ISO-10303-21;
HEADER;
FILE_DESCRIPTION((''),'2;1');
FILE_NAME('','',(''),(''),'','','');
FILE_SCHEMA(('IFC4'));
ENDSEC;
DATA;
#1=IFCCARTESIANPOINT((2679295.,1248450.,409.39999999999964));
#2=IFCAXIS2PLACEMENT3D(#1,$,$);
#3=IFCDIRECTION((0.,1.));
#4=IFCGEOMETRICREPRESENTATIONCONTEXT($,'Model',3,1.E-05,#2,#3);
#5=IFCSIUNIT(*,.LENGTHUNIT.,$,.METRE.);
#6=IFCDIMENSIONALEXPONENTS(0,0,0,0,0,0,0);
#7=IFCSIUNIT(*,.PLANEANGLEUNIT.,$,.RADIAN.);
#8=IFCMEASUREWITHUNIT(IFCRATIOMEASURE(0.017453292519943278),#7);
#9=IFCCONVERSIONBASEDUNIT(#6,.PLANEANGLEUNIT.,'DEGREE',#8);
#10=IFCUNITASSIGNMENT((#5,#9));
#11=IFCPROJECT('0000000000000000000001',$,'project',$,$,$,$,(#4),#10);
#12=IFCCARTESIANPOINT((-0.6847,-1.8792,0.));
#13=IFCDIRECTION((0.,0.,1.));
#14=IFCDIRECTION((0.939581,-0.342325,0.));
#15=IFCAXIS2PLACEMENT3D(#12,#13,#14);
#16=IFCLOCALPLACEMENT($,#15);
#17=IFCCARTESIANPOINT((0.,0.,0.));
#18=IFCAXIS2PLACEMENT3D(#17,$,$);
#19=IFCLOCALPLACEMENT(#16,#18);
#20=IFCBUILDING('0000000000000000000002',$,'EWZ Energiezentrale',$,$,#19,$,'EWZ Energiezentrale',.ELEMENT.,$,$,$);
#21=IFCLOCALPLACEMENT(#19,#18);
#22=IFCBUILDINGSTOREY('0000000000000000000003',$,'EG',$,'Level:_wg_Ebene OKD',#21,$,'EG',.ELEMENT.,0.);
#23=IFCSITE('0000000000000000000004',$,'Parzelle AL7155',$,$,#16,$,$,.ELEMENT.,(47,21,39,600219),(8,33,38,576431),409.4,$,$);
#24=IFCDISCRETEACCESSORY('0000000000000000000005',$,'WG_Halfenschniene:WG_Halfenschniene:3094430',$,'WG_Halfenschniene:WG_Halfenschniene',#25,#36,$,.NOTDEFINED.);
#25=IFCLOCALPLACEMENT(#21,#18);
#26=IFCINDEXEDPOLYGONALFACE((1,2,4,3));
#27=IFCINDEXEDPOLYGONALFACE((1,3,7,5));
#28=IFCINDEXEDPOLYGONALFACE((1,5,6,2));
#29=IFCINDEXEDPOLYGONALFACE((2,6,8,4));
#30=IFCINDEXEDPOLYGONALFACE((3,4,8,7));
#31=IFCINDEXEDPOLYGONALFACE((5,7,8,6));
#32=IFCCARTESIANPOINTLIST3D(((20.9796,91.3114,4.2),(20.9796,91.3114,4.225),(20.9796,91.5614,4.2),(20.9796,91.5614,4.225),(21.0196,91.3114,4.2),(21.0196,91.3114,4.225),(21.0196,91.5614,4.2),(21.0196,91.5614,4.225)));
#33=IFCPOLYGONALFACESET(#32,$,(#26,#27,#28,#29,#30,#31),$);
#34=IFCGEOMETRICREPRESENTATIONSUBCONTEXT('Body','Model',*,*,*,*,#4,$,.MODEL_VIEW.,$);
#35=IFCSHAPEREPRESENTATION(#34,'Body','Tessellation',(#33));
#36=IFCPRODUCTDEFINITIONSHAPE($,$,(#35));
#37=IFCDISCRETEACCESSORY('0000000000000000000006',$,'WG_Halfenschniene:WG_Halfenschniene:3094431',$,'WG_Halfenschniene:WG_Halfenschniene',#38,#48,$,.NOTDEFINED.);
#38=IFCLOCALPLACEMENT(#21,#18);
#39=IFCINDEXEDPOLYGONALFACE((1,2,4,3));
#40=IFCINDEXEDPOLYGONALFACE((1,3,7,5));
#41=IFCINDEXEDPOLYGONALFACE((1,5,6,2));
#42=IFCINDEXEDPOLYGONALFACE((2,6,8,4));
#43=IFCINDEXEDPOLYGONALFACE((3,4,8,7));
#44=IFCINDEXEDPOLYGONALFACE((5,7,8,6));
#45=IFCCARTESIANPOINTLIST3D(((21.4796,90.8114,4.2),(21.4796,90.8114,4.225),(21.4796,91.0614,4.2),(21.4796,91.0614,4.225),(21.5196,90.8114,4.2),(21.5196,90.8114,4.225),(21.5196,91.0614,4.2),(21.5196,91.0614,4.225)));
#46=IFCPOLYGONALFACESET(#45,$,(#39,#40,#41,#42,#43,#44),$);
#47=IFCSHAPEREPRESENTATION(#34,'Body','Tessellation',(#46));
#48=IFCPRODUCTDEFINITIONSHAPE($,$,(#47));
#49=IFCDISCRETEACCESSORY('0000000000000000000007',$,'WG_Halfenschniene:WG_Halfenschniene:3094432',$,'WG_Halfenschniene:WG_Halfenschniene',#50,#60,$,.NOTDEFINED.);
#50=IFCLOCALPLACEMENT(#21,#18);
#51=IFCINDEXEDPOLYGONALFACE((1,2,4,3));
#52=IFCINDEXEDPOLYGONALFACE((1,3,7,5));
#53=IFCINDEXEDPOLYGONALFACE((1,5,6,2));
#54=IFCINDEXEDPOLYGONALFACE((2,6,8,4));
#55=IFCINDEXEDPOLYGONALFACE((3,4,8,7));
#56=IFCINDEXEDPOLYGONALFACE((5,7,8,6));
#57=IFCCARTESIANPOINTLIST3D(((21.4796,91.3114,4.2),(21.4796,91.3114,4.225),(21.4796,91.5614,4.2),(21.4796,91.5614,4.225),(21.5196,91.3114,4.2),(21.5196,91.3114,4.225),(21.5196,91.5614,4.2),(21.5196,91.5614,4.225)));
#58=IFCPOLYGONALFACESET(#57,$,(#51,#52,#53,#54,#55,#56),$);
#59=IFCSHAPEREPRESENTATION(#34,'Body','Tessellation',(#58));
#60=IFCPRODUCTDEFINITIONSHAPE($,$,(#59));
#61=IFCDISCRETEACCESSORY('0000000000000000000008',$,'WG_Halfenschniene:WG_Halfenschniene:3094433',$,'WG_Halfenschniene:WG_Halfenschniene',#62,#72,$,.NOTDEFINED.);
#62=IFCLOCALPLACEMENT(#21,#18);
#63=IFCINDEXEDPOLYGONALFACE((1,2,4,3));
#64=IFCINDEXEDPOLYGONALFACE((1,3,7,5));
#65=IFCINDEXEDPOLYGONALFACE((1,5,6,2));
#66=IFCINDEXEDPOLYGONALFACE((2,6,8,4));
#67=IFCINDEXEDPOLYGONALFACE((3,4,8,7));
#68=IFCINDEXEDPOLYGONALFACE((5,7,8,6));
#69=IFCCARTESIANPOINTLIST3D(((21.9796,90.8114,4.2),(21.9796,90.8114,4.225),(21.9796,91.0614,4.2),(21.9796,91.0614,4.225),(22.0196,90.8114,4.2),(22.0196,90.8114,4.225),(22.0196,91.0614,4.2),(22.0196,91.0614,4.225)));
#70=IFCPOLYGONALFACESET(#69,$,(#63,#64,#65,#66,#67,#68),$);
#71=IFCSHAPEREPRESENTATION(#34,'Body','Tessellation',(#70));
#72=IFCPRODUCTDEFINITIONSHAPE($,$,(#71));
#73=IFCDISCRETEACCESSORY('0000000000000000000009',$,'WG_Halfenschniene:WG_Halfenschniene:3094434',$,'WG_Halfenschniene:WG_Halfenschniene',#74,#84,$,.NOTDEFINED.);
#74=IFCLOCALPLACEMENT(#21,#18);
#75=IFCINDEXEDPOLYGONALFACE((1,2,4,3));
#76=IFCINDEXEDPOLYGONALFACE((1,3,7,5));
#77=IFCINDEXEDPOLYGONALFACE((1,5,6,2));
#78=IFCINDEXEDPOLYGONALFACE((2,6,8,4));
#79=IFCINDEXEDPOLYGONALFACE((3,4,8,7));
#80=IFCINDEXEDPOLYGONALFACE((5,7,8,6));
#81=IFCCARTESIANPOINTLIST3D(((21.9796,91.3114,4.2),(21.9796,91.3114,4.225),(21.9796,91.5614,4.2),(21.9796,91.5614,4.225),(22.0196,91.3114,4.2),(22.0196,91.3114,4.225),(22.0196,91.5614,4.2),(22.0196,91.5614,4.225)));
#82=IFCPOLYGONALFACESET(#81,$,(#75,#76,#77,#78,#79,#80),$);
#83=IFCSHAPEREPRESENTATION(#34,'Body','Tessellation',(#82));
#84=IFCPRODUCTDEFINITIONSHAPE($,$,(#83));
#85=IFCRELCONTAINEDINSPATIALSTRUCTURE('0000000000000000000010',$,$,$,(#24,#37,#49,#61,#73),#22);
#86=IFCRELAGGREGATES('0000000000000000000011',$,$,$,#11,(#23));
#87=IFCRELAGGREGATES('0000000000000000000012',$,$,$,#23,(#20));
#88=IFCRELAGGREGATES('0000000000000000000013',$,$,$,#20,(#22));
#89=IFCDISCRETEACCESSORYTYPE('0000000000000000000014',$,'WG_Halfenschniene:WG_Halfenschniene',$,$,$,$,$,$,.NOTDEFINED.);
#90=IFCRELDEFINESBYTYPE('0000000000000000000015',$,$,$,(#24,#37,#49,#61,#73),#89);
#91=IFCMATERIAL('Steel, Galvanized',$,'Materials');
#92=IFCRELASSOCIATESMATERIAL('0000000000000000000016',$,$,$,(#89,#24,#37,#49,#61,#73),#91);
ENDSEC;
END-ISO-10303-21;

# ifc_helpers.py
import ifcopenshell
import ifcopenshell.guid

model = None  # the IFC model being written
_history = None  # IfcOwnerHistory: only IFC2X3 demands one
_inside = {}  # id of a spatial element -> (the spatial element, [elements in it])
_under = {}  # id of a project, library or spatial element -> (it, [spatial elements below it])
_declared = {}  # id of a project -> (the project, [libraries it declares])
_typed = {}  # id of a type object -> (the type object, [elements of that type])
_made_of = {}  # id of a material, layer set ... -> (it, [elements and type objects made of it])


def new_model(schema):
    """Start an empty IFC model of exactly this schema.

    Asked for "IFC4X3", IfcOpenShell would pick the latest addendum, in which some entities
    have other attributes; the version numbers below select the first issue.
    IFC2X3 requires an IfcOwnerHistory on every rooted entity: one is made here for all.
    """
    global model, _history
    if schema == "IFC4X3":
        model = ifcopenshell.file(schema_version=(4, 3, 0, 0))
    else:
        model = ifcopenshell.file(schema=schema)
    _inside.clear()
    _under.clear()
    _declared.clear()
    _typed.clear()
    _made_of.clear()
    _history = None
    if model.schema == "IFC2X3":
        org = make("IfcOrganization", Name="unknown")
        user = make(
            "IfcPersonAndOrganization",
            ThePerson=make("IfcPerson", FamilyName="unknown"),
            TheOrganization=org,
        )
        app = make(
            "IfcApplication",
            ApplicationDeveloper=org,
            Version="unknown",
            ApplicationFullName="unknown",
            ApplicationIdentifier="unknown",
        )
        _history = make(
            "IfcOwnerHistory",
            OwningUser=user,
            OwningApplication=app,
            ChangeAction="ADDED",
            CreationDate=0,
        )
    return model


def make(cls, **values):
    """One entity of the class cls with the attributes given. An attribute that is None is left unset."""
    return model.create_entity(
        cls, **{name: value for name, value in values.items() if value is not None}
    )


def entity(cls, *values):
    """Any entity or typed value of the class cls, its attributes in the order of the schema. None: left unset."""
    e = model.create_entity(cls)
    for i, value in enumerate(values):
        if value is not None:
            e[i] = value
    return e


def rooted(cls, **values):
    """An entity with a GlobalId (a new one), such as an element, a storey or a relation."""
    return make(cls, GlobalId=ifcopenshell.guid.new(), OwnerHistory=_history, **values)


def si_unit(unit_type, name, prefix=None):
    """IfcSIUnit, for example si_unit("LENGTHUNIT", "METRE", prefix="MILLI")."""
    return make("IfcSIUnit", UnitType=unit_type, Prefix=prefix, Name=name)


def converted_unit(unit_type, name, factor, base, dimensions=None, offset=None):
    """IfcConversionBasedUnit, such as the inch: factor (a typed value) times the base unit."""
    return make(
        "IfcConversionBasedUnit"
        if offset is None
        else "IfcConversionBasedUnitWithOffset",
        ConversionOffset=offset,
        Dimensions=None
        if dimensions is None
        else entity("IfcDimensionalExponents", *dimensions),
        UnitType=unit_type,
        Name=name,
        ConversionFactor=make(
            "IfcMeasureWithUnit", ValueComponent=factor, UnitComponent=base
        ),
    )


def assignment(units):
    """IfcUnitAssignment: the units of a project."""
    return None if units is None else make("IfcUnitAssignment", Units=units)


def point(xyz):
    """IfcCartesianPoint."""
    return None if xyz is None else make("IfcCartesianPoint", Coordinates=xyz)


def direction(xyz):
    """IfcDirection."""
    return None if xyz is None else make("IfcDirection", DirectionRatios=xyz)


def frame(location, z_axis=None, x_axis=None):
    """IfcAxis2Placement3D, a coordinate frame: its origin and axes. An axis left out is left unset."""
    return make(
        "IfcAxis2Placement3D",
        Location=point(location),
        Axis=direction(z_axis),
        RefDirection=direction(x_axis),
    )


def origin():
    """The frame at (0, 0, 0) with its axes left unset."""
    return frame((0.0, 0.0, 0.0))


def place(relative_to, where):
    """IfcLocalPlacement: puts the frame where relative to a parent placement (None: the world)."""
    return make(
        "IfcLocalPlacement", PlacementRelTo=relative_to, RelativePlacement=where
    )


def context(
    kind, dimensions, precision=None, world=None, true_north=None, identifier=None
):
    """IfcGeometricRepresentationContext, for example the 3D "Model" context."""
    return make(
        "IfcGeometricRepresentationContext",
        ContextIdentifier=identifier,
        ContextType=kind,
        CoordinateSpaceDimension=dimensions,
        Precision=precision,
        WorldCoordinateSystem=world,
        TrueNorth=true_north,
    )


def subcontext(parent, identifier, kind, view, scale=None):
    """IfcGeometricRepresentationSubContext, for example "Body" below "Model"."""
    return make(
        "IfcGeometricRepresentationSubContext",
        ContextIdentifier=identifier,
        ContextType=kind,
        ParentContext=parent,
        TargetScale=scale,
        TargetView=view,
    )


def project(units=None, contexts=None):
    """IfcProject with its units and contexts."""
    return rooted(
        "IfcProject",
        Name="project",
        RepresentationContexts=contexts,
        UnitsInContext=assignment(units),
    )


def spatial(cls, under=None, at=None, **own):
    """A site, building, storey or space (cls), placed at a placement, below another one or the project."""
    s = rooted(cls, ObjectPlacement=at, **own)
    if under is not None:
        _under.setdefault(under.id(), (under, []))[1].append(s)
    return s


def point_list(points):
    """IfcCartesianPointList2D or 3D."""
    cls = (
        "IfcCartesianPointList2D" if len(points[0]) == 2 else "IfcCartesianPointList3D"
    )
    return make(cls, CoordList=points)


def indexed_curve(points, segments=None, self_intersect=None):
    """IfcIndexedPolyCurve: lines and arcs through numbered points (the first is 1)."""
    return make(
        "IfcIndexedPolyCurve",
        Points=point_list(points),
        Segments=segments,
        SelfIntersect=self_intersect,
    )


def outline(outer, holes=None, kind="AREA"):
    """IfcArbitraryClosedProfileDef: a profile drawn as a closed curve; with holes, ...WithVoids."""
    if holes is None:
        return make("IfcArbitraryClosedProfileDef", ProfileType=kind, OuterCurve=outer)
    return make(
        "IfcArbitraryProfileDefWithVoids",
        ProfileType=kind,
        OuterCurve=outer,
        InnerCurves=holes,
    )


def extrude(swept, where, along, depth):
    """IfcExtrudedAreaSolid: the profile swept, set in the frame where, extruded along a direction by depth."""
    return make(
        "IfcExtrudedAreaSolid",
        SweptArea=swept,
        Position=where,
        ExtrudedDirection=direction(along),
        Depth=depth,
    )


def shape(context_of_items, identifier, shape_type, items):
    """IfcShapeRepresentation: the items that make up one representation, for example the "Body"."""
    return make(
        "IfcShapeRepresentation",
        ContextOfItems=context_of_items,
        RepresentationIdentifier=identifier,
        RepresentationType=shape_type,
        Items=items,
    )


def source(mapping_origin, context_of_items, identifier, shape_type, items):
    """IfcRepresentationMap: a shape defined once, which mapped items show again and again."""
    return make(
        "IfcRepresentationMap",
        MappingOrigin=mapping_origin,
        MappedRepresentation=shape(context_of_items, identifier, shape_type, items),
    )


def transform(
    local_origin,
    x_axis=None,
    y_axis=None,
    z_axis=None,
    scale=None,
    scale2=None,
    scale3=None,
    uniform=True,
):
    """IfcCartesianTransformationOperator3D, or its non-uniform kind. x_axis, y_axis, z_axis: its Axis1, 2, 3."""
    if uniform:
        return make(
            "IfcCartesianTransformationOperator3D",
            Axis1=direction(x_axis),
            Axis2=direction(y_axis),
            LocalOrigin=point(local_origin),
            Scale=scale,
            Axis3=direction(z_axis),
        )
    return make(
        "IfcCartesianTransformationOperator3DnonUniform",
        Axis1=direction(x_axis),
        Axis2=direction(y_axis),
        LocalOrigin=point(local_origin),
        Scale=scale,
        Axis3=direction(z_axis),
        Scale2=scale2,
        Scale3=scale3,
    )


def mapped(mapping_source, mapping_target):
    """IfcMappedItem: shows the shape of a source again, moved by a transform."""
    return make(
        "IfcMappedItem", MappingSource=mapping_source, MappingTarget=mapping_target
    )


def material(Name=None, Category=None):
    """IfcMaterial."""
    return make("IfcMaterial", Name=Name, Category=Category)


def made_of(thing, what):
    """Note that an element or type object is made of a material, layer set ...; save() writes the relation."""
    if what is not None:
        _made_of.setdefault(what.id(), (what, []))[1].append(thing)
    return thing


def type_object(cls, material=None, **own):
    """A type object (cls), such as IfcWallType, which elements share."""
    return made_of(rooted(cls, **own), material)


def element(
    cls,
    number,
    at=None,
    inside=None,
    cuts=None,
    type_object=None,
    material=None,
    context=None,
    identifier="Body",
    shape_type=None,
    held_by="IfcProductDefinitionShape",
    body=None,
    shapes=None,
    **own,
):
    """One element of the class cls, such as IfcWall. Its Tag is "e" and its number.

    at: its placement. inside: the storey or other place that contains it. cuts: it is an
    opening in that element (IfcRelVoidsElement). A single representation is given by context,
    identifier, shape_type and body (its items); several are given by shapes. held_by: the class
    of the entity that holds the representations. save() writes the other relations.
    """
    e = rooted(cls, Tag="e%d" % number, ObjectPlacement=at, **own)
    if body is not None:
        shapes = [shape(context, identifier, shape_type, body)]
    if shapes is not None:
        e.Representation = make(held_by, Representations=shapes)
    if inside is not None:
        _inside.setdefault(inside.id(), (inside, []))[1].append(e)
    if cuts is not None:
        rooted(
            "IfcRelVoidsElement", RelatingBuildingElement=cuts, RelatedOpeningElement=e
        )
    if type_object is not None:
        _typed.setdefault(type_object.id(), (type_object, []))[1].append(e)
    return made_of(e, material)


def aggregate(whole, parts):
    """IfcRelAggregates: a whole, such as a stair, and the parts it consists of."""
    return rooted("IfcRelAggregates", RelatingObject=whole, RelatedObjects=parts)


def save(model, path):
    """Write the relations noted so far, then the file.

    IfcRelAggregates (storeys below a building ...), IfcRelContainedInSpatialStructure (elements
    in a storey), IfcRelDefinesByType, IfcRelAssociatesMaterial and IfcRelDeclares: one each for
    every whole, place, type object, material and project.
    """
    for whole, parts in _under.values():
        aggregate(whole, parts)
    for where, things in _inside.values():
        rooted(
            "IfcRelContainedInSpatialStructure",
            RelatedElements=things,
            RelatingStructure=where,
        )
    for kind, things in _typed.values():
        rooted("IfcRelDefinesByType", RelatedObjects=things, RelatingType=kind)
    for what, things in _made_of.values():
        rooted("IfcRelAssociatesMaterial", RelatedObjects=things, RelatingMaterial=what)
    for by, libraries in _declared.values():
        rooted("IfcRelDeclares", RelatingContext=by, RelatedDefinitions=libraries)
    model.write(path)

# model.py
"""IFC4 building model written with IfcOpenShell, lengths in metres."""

from ifc_helpers import new_model, entity, si_unit, converted_unit, direction, frame, origin, place, context, subcontext, project, spatial, indexed_curve, outline, extrude, source, transform, mapped, material, type_object, element, save


model = new_model("IFC4")

# Units and contexts
model_context = context("Model", 3, precision=1e-05, world=frame((2679295.0, 1248450.0, 409.39999999999964)), true_north=direction((0.0, 1.0)))
body_context = subcontext(model_context, "Body", "Model", "MODEL_VIEW")
ifc_project = project(units=[si_unit("LENGTHUNIT", "METRE"), converted_unit("PLANEANGLEUNIT", "DEGREE", entity("IfcRatioMeasure", 0.017453292519943278), si_unit("PLANEANGLEUNIT", "RADIAN"), dimensions=[0, 0, 0, 0, 0, 0, 0])], contexts=[model_context])

# Site, building, storey
site_placement = place(None, frame((-0.6847, -1.8792, 0.0), z_axis=(0.0, 0.0, 1.0), x_axis=(0.939581, -0.342325, 0.0)))
site = spatial("IfcSite", under=ifc_project, at=site_placement, Name="Parzelle AL7155", CompositionType="ELEMENT", RefLatitude=(47, 21, 39, 600219), RefLongitude=(8, 33, 38, 576431), RefElevation=409.4)
building_placement = place(site_placement, origin())
building = spatial("IfcBuilding", under=site, at=building_placement, Name="EWZ Energiezentrale", LongName="EWZ Energiezentrale", CompositionType="ELEMENT")
storey_placement = place(building_placement, origin())
storey = spatial("IfcBuildingStorey", under=building, at=storey_placement, Name="EG", ObjectType="Level:_wg_Ebene OKD", LongName="EG", CompositionType="ELEMENT", Elevation=0.0)

# Discrete accessories
ifc_material_1 = material(Name="Steel, Galvanized", Category="Materials")
discrete_accessory_type = type_object("IfcDiscreteAccessoryType", Name="WG_Halfenschniene:WG_Halfenschniene", PredefinedType="NOTDEFINED", material=ifc_material_1)
shared_shape_1 = source(origin(), body_context, "Body", "SweptSolid", [
    extrude(outline(indexed_curve([(-0.125, -0.02), (0.125, -0.02), (0.125, 0.02), (-0.125, 0.02), (-0.125, -0.02)], self_intersect=False)), frame((0.125, 0.0, -0.0125)), (0.0, 0.0, 1.0), 0.025),
])
for number, where, z_axis, x_axis, name in (
    (1, (20.9996, 91.3114, 4.2125), (0.0, 0.0, -1.0), (0.0, 1.0, 0.0), "WG_Halfenschniene:WG_Halfenschniene:3094430"),
    (2, (21.4996, 90.8114, 4.2125), (0.0, 0.0, -1.0), (0.0, 1.0, 0.0), "WG_Halfenschniene:WG_Halfenschniene:3094431"),
    (3, (21.4996, 91.3114, 4.2125), (0.0, 0.0, -1.0), (0.0, 1.0, 0.0), "WG_Halfenschniene:WG_Halfenschniene:3094432"),
    (4, (21.9996, 90.8114, 4.2125), (0.0, 0.0, -1.0), (0.0, 1.0, 0.0), "WG_Halfenschniene:WG_Halfenschniene:3094433"),
    (5, (21.9996, 91.3114, 4.2125), (0.0, 0.0, -1.0), (0.0, 1.0, 0.0), "WG_Halfenschniene:WG_Halfenschniene:3094434"),
):
    element("IfcDiscreteAccessory", number, at=place(storey_placement, frame(where, z_axis=z_axis, x_axis=x_axis)), inside=storey, type_object=discrete_accessory_type, material=ifc_material_1, Name=name, ObjectType="WG_Halfenschniene:WG_Halfenschniene", PredefinedType="NOTDEFINED", context=body_context, shape_type="MappedRepresentation", body=[
        mapped(shared_shape_1, transform((0.0, 0.0, 0.0), scale=1.0)),
    ])

save(model, "model.ifc")
